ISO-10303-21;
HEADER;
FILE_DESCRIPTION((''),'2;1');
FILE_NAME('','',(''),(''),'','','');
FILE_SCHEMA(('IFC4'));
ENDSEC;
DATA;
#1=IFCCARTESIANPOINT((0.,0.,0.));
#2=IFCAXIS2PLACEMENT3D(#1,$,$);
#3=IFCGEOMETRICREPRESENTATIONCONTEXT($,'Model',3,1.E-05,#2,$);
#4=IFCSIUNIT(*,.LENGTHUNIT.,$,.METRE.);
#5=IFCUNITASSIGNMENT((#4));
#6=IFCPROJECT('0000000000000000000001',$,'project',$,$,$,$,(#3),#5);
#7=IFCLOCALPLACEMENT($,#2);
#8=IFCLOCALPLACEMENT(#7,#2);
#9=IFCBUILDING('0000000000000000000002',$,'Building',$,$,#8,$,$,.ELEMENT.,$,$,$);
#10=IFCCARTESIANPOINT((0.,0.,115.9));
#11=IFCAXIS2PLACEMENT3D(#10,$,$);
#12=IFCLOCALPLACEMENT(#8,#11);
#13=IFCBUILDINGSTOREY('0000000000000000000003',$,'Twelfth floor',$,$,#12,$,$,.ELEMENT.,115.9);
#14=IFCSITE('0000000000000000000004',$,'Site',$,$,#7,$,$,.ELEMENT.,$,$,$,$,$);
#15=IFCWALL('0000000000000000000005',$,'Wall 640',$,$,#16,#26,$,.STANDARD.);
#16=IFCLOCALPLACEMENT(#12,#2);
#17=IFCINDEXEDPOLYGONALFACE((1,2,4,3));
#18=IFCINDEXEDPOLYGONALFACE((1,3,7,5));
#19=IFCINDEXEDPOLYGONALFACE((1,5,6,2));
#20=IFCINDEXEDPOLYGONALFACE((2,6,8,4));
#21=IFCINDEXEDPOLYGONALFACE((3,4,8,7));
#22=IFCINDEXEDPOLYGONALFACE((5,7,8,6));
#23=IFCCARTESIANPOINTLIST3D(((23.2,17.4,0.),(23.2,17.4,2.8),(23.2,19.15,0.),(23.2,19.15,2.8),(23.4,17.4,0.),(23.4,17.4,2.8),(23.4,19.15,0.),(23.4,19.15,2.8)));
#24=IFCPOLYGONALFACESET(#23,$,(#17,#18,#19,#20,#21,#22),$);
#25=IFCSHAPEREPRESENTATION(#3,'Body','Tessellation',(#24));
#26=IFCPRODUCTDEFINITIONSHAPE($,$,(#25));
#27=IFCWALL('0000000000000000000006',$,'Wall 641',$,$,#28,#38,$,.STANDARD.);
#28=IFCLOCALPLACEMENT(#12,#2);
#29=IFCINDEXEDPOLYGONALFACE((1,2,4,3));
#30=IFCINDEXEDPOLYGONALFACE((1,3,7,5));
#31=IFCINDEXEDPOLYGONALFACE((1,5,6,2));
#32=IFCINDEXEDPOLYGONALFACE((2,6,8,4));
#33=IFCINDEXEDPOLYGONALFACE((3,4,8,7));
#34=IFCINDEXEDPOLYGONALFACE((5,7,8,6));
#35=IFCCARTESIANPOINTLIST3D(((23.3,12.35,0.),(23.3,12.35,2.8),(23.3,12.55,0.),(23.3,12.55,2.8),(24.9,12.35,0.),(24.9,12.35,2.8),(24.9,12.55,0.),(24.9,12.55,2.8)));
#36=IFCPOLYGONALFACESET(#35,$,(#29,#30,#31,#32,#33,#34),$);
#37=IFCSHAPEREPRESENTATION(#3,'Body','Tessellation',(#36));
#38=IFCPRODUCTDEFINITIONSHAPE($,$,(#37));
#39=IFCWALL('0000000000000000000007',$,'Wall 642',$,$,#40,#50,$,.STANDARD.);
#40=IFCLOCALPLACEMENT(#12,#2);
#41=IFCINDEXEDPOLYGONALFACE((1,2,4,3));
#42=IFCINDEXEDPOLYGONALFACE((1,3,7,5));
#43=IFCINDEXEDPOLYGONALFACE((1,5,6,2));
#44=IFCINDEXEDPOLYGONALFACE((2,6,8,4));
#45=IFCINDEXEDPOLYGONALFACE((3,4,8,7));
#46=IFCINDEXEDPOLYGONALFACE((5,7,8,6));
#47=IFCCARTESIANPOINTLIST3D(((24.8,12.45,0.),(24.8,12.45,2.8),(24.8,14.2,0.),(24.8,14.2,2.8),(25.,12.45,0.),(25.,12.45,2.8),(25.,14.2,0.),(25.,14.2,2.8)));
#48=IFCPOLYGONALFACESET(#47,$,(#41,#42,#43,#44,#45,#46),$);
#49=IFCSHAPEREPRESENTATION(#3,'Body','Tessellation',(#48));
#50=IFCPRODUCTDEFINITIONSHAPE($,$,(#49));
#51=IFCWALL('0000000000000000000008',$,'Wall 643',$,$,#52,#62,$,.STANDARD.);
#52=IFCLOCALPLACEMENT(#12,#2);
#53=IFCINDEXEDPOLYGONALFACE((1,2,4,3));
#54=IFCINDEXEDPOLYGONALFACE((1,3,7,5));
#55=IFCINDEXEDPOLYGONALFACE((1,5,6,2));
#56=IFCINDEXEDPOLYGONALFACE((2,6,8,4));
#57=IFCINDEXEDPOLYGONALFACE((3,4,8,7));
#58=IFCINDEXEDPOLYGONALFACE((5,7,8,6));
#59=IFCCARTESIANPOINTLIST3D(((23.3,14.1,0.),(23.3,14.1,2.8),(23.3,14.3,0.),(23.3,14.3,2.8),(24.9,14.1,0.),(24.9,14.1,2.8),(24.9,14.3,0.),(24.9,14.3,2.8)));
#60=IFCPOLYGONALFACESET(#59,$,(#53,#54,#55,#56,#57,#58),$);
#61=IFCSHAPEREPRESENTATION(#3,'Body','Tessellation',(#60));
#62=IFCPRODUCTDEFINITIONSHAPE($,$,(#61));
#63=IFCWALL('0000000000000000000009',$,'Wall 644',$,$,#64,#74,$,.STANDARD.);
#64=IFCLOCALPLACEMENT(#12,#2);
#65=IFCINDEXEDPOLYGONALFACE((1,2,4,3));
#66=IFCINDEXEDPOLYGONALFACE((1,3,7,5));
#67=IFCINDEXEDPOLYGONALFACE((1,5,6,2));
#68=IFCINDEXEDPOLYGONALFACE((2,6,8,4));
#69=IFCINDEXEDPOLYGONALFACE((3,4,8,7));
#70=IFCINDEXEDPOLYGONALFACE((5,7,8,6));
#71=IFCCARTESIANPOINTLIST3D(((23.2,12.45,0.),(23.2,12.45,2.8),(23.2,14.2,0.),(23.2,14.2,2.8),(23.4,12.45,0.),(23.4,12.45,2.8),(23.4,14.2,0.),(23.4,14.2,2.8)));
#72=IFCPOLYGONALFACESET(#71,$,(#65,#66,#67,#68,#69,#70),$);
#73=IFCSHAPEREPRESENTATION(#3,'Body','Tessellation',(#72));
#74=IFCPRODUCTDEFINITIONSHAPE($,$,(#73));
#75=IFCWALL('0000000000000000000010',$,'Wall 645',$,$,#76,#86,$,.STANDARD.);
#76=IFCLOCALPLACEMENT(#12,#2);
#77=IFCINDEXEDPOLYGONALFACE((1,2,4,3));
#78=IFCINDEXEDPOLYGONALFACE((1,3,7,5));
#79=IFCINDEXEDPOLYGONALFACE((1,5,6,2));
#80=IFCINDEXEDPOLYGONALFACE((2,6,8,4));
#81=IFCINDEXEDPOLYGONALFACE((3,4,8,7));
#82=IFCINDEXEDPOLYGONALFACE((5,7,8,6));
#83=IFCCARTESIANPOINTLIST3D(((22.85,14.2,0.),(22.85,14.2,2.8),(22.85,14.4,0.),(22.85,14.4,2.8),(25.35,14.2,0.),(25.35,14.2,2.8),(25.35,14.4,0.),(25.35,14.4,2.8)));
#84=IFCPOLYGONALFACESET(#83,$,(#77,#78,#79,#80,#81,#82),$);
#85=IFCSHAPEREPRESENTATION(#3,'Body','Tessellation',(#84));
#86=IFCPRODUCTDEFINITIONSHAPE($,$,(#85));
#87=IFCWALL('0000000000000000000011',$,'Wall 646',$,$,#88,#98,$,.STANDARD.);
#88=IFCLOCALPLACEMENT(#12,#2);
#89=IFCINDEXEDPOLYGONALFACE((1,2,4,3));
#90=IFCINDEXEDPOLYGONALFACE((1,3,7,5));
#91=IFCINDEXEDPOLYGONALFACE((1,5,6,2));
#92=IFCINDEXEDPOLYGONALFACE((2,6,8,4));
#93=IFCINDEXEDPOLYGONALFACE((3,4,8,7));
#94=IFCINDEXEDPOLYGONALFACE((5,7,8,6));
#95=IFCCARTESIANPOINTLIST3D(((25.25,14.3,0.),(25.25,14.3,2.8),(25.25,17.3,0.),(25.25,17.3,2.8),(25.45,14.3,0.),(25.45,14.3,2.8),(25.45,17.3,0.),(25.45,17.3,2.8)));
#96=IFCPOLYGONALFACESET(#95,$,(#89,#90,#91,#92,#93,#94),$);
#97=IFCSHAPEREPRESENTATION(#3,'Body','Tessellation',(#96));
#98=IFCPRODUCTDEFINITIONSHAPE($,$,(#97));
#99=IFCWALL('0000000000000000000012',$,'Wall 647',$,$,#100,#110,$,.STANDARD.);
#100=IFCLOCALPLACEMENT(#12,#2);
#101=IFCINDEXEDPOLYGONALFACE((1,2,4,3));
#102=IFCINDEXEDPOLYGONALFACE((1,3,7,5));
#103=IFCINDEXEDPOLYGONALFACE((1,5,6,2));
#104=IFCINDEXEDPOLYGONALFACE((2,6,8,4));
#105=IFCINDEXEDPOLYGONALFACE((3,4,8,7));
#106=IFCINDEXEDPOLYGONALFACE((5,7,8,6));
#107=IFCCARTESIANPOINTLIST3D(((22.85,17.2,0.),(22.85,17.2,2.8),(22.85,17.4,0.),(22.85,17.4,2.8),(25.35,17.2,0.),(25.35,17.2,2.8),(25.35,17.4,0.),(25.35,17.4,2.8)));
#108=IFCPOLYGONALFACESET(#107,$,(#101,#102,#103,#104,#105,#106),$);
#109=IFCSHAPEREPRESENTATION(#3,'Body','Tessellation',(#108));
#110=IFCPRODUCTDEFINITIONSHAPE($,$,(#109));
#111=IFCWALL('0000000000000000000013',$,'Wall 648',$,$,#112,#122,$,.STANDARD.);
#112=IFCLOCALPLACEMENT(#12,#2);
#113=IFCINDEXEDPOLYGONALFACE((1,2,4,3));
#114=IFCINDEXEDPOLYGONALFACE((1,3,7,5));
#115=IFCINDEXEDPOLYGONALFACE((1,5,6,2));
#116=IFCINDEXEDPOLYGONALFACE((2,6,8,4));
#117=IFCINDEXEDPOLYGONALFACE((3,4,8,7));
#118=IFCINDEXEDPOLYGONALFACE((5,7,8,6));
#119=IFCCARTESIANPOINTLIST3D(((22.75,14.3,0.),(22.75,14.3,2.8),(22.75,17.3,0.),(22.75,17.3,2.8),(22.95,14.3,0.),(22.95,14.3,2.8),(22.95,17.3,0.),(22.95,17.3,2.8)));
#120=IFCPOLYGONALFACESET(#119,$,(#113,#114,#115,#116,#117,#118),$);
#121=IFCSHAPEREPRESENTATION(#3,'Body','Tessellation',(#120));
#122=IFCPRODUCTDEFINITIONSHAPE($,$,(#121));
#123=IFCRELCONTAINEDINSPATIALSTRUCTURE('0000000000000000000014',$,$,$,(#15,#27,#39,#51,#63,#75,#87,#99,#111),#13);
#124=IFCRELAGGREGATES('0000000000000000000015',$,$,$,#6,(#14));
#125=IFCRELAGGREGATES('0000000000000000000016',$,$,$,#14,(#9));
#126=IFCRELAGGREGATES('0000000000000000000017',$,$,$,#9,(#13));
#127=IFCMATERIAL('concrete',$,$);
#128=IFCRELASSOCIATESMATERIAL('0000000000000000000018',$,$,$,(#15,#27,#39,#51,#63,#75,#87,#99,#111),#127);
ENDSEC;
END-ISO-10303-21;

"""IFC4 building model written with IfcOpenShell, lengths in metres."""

from ifc_helpers import new_model, si_unit, frame, frame_2d, origin, place, context, project, spatial, rectangle, extrude, material, element, save


model = new_model("IFC4")

# Units and contexts
model_context = context("Model", 3, precision=1e-05, world=origin())
ifc_project = project(units=[si_unit("LENGTHUNIT", "METRE")], contexts=[model_context])

# Site, building, storey
site_placement = place(None, origin())
site = spatial("IfcSite", under=ifc_project, at=site_placement, Name="Site", CompositionType="ELEMENT")
building_placement = place(site_placement, origin())
building = spatial("IfcBuilding", under=site, at=building_placement, Name="Building", CompositionType="ELEMENT")
storey_placement = place(building_placement, frame((0.0, 0.0, 115.9)))
storey = spatial("IfcBuildingStorey", under=building, at=storey_placement, Name="Twelfth floor", CompositionType="ELEMENT", Elevation=115.9)

# Shared definitions
ifc_material = material(Name="concrete")

# Walls
wall_1_placement = place(storey_placement, frame((23.3, 19.15, 0.0), z_axis=(0.0, 0.0, 1.0), x_axis=(0.0, -1.0, 0.0)))
element("IfcWall", 1, at=wall_1_placement, inside=storey, material=ifc_material, Name="Wall 640", PredefinedType="STANDARD", context=model_context, shape_type="SweptSolid", body=[
    extrude(rectangle(XDim=1.75, YDim=0.2, at=frame_2d((0.875, 0.0))), origin(), (0.0, 0.0, 1.0), 2.8),
])
wall_2_placement = place(storey_placement, frame((23.3, 12.45, 0.0), z_axis=(0.0, 0.0, 1.0), x_axis=(1.0, 0.0, 0.0)))
element("IfcWall", 2, at=wall_2_placement, inside=storey, material=ifc_material, Name="Wall 641", PredefinedType="STANDARD", context=model_context, shape_type="SweptSolid", body=[
    extrude(rectangle(XDim=1.6, YDim=0.2, at=frame_2d((0.8, 0.0))), origin(), (0.0, 0.0, 1.0), 2.8),
])
wall_3_placement = place(storey_placement, frame((24.9, 12.45, 0.0), z_axis=(0.0, 0.0, 1.0), x_axis=(0.0, 1.0, 0.0)))
element("IfcWall", 3, at=wall_3_placement, inside=storey, material=ifc_material, Name="Wall 642", PredefinedType="STANDARD", context=model_context, shape_type="SweptSolid", body=[
    extrude(rectangle(XDim=1.75, YDim=0.2, at=frame_2d((0.875, 0.0))), origin(), (0.0, 0.0, 1.0), 2.8),
])
wall_4_placement = place(storey_placement, frame((24.9, 14.2, 0.0), z_axis=(0.0, 0.0, 1.0), x_axis=(-1.0, 0.0, 0.0)))
element("IfcWall", 4, at=wall_4_placement, inside=storey, material=ifc_material, Name="Wall 643", PredefinedType="STANDARD", context=model_context, shape_type="SweptSolid", body=[
    extrude(rectangle(XDim=1.6, YDim=0.2, at=frame_2d((0.8, 0.0))), origin(), (0.0, 0.0, 1.0), 2.8),
])
wall_5_placement = place(storey_placement, frame((23.3, 14.2, 0.0), z_axis=(0.0, 0.0, 1.0), x_axis=(0.0, -1.0, 0.0)))
element("IfcWall", 5, at=wall_5_placement, inside=storey, material=ifc_material, Name="Wall 644", PredefinedType="STANDARD", context=model_context, shape_type="SweptSolid", body=[
    extrude(rectangle(XDim=1.75, YDim=0.2, at=frame_2d((0.875, 0.0))), origin(), (0.0, 0.0, 1.0), 2.8),
])
wall_6_placement = place(storey_placement, frame((22.85, 14.3, 0.0), z_axis=(0.0, 0.0, 1.0), x_axis=(1.0, 0.0, 0.0)))
element("IfcWall", 6, at=wall_6_placement, inside=storey, material=ifc_material, Name="Wall 645", PredefinedType="STANDARD", context=model_context, shape_type="SweptSolid", body=[
    extrude(rectangle(XDim=2.5, YDim=0.2, at=frame_2d((1.25, 0.0))), origin(), (0.0, 0.0, 1.0), 2.8),
])
wall_7_placement = place(storey_placement, frame((25.35, 14.3, 0.0), z_axis=(0.0, 0.0, 1.0), x_axis=(0.0, 1.0, 0.0)))
element("IfcWall", 7, at=wall_7_placement, inside=storey, material=ifc_material, Name="Wall 646", PredefinedType="STANDARD", context=model_context, shape_type="SweptSolid", body=[
    extrude(rectangle(XDim=3.0, YDim=0.2, at=frame_2d((1.5, 0.0))), origin(), (0.0, 0.0, 1.0), 2.8),
])
wall_8_placement = place(storey_placement, frame((25.35, 17.3, 0.0), z_axis=(0.0, 0.0, 1.0), x_axis=(-1.0, 0.0, 0.0)))
element("IfcWall", 8, at=wall_8_placement, inside=storey, material=ifc_material, Name="Wall 647", PredefinedType="STANDARD", context=model_context, shape_type="SweptSolid", body=[
    extrude(rectangle(XDim=2.5, YDim=0.2, at=frame_2d((1.25, 0.0))), origin(), (0.0, 0.0, 1.0), 2.8),
])
wall_9_placement = place(storey_placement, frame((22.85, 17.3, 0.0), z_axis=(0.0, 0.0, 1.0), x_axis=(0.0, -1.0, 0.0)))
element("IfcWall", 9, at=wall_9_placement, inside=storey, material=ifc_material, Name="Wall 648", PredefinedType="STANDARD", context=model_context, shape_type="SweptSolid", body=[
    extrude(rectangle(XDim=3.0, YDim=0.2, at=frame_2d((1.5, 0.0))), origin(), (0.0, 0.0, 1.0), 2.8),
])

save(model, "model.ifc")
